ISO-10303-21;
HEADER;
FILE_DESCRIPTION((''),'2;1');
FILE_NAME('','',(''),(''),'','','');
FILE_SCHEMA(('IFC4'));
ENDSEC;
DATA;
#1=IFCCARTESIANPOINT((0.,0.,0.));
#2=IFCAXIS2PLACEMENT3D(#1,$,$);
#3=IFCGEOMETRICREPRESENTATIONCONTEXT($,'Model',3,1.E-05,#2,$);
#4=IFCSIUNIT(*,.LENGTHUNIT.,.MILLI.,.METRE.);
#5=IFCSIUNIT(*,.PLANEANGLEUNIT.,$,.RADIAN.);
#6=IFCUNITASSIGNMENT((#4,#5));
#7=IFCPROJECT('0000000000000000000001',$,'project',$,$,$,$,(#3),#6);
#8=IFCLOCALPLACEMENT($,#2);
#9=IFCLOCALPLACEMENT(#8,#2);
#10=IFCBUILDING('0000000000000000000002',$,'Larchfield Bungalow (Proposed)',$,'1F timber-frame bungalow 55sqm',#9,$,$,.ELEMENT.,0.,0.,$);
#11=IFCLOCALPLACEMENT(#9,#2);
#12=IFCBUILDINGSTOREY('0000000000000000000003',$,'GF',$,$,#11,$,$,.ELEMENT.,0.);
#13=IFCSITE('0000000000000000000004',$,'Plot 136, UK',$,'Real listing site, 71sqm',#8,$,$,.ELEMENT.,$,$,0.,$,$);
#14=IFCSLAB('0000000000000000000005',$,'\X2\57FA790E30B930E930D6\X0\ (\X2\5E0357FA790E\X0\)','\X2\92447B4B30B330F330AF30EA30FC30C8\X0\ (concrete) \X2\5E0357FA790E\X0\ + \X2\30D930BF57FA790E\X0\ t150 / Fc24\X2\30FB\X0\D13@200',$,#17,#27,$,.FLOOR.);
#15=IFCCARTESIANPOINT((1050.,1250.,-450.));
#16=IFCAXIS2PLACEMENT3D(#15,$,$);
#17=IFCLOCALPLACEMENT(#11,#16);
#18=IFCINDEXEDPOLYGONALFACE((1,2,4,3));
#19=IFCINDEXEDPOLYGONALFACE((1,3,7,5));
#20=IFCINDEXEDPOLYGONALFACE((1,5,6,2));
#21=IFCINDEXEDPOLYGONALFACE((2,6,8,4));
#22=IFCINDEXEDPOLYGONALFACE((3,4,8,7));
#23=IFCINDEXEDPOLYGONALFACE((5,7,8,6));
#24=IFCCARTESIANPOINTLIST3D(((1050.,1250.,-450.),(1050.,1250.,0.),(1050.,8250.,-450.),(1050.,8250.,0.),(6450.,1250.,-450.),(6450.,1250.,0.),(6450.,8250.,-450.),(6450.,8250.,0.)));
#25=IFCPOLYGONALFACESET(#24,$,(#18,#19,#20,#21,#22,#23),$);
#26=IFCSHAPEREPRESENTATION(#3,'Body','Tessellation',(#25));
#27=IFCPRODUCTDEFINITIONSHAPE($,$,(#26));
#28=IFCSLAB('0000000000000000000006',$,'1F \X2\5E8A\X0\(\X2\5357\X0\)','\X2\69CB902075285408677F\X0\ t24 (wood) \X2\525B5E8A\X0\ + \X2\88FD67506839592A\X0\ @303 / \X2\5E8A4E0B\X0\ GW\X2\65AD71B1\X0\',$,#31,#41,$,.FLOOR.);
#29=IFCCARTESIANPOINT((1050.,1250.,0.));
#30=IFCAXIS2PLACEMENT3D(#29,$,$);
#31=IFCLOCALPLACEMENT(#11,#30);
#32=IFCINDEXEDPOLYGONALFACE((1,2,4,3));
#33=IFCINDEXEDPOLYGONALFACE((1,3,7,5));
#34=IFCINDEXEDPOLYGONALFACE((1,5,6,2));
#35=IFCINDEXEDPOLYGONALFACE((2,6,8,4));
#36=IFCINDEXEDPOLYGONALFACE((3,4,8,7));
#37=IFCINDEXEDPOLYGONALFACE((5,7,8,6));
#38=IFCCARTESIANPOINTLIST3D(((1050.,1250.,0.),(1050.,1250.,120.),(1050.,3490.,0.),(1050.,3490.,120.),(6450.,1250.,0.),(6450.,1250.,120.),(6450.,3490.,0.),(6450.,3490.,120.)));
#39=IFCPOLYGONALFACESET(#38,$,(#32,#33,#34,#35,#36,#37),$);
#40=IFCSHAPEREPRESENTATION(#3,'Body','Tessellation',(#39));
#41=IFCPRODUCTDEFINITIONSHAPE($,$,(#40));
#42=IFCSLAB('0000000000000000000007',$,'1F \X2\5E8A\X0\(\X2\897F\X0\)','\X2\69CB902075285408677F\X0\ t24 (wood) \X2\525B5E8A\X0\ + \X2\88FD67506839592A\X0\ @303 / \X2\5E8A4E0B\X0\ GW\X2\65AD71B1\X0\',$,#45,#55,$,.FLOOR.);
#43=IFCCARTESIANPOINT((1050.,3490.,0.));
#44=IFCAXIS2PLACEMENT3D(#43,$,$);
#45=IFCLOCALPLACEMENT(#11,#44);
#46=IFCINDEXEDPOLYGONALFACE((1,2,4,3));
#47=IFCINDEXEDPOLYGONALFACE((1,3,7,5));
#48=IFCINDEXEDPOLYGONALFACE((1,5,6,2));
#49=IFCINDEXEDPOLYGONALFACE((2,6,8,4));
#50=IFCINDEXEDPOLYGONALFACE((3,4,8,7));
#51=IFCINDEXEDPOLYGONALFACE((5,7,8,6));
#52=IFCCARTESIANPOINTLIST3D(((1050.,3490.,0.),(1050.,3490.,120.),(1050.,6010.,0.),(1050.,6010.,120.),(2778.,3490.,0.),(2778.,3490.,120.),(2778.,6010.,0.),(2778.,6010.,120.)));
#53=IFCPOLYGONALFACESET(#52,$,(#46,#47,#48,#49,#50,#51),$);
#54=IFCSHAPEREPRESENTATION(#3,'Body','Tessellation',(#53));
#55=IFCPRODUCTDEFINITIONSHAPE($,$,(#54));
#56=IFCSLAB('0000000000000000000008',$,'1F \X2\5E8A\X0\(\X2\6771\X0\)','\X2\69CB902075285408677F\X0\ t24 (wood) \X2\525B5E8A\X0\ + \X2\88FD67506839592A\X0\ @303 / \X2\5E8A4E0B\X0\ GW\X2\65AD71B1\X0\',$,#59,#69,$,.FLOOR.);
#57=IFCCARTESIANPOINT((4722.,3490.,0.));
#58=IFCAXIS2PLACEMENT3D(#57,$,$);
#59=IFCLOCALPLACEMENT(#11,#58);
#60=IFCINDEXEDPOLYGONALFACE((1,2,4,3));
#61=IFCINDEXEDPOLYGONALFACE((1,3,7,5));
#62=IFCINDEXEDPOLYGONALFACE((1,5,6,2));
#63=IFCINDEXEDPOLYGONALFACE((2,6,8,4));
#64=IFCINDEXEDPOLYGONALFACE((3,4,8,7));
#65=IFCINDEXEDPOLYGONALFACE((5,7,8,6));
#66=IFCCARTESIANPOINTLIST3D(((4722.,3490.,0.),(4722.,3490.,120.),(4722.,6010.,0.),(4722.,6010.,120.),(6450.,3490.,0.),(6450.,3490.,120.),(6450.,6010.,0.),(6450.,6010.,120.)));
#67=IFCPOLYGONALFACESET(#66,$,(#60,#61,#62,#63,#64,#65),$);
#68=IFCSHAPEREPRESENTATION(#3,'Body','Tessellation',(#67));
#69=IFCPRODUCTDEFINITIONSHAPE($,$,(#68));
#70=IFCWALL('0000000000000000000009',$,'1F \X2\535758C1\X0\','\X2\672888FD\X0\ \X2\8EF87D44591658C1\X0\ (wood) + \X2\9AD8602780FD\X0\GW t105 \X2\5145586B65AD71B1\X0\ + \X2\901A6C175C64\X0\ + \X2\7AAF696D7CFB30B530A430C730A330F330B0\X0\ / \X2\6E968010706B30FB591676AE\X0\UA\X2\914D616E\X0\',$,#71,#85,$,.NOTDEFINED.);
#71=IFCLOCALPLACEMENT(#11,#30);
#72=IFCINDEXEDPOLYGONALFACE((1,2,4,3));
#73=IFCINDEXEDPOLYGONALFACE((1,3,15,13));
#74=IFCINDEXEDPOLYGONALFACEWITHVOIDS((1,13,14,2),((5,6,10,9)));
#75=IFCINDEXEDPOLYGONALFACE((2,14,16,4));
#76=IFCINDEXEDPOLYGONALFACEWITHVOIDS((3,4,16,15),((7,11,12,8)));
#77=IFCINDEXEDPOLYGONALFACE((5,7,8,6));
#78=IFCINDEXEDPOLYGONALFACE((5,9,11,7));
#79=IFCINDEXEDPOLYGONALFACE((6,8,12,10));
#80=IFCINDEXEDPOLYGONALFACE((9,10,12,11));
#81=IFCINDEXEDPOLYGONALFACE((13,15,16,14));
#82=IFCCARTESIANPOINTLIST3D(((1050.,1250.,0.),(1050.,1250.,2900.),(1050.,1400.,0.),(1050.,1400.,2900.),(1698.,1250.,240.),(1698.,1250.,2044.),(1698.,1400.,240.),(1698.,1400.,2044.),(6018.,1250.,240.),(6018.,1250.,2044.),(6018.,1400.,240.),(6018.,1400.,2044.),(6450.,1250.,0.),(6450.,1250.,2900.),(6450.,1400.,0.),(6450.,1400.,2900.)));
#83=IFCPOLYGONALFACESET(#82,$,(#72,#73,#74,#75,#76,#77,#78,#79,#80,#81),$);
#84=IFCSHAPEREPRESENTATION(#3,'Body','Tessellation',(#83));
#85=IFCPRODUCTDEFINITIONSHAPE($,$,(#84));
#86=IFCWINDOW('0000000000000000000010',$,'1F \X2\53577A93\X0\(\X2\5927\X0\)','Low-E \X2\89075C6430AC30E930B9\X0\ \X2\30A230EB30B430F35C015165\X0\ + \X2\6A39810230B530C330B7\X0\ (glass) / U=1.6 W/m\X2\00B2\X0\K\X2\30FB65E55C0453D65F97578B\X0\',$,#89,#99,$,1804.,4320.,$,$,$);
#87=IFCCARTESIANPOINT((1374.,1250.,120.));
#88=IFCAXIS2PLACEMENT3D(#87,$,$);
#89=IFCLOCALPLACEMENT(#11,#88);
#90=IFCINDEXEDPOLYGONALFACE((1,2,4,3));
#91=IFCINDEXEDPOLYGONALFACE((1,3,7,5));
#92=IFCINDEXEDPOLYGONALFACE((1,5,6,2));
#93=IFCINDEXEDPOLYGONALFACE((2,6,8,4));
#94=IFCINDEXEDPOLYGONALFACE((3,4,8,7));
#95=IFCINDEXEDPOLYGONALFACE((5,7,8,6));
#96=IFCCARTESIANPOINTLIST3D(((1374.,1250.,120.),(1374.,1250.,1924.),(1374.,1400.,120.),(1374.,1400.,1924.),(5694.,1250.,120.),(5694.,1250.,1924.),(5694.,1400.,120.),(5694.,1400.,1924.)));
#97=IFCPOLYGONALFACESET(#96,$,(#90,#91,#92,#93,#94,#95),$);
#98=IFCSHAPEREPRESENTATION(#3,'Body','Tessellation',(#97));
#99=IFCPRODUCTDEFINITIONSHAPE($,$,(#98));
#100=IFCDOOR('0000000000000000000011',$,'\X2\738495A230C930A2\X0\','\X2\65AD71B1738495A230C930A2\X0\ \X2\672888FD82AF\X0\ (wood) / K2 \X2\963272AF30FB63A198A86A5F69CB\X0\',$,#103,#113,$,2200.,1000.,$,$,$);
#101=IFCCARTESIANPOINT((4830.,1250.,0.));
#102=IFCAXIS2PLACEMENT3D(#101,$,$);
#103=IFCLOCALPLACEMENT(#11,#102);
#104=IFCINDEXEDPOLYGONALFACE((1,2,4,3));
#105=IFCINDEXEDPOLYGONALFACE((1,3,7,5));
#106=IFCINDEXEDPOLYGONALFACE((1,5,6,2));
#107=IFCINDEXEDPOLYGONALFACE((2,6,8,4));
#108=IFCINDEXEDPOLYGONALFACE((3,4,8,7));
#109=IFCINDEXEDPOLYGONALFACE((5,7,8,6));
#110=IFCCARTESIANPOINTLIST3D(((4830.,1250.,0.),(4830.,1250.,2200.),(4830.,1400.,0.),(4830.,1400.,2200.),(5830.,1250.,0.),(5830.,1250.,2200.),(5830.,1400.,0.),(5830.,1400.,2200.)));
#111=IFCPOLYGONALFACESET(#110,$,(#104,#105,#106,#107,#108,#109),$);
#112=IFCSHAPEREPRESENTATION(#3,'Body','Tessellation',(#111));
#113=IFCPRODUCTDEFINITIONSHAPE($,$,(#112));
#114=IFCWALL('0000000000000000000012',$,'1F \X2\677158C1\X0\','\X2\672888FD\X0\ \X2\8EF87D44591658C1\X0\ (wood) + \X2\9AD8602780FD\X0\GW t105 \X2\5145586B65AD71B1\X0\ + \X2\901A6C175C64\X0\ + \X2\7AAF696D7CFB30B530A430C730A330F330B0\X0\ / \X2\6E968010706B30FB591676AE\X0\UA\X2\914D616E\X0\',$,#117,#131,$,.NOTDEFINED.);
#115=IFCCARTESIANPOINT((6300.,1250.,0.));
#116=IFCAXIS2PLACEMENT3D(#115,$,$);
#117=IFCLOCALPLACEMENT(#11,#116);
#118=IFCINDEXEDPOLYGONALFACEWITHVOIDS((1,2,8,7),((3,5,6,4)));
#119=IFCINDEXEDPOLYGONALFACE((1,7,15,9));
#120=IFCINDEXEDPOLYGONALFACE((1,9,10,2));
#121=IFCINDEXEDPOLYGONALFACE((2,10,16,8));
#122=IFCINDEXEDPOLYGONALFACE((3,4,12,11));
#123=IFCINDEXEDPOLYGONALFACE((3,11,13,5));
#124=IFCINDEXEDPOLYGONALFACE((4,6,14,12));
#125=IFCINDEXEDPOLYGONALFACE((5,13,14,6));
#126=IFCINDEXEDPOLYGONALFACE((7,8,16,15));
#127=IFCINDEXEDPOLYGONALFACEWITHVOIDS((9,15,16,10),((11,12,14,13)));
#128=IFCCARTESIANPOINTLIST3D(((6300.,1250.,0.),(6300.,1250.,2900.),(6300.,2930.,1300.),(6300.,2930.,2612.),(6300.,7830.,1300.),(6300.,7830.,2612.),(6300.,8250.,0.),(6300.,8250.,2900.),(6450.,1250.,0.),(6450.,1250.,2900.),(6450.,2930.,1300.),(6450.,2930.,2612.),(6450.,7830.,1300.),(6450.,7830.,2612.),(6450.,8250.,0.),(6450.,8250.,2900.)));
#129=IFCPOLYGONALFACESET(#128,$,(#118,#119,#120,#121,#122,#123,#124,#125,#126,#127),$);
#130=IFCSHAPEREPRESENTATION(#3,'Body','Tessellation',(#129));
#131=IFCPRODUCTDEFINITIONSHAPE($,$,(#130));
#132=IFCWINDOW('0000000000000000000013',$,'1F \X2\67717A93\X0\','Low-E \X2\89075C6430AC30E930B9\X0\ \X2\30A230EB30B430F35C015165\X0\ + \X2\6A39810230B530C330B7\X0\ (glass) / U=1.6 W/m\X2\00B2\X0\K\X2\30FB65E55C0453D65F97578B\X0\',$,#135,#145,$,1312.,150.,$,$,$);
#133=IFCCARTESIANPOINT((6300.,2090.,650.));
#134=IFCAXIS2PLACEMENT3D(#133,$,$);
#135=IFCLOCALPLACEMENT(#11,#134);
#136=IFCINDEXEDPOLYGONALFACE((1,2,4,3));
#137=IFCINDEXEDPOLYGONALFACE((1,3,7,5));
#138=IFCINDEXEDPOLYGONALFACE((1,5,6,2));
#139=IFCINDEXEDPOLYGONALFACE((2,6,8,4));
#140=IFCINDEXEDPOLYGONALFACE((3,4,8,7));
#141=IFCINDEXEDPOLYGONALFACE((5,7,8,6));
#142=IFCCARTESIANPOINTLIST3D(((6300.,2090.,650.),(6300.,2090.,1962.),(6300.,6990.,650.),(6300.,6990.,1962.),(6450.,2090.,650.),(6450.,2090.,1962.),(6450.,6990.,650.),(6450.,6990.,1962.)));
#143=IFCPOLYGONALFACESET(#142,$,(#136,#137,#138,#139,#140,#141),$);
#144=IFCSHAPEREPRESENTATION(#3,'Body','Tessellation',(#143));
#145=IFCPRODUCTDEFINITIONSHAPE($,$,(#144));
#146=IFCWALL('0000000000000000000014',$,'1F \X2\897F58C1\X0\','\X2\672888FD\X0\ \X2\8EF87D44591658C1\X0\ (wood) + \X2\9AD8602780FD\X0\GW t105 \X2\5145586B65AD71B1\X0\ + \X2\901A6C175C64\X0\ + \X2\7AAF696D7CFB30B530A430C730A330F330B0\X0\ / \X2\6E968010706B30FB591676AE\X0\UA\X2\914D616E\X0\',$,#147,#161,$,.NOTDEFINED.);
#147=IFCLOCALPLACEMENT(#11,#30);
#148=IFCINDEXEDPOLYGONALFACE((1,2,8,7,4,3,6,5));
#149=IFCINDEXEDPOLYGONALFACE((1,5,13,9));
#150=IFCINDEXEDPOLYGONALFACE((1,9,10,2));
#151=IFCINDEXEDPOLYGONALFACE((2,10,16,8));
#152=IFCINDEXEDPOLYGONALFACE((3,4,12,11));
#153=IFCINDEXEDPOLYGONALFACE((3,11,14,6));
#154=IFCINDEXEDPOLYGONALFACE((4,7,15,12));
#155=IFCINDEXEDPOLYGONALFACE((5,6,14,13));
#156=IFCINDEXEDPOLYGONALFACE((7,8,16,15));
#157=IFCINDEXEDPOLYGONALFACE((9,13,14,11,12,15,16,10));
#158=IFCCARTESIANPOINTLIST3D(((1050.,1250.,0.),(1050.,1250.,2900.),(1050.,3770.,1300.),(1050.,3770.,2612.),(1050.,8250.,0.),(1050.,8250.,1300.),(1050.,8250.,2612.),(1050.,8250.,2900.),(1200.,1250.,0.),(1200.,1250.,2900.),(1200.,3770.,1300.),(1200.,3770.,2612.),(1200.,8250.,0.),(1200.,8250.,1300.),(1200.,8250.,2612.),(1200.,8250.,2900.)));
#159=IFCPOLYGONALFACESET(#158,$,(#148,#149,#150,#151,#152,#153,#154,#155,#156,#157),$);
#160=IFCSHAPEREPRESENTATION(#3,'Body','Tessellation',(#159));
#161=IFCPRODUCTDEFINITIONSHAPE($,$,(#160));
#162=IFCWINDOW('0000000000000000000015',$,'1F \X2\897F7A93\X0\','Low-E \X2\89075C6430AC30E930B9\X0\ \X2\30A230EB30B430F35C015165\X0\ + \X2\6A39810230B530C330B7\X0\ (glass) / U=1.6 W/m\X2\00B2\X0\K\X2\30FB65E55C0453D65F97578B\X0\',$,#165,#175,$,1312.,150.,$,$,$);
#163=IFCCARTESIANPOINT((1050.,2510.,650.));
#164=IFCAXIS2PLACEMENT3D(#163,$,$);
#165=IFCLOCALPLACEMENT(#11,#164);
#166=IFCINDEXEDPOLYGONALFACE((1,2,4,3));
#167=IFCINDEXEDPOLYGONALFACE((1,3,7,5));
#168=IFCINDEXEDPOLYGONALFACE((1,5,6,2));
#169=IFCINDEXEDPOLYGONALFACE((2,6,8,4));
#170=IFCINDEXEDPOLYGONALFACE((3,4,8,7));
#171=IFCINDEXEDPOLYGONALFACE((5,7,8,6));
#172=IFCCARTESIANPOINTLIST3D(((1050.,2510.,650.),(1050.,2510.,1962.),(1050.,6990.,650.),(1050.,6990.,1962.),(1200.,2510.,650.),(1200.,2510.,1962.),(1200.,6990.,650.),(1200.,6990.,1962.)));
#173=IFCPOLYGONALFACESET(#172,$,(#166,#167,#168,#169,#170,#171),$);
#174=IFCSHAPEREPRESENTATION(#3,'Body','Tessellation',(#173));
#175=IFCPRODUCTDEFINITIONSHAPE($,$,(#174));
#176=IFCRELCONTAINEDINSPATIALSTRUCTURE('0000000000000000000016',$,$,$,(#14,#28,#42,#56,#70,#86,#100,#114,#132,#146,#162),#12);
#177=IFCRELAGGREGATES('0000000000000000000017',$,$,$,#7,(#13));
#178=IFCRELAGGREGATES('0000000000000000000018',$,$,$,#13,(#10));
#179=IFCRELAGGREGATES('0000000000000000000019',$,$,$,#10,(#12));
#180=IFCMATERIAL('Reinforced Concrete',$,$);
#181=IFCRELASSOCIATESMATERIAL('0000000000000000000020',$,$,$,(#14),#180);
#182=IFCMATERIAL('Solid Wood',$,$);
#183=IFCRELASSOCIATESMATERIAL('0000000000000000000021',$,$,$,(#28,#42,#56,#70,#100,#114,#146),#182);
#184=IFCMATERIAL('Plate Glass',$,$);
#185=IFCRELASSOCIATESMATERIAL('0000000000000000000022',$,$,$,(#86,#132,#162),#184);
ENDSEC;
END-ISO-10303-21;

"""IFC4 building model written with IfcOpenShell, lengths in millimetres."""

from ifc_helpers import new_model, si_unit, frame, frame_2d, origin, place, context, project, spatial, rectangle, extrude, material, element, fill, save


model = new_model("IFC4")

# Units and contexts
model_context = context("Model", 3, precision=1e-05, world=origin())
ifc_project = project(units=[si_unit("LENGTHUNIT", "METRE", prefix="MILLI"), si_unit("PLANEANGLEUNIT", "RADIAN")], contexts=[model_context])

# Site, building, storey
site_placement = place(None, origin())
site = spatial("IfcSite", under=ifc_project, at=site_placement, Name="Plot 136, UK", ObjectType="Real listing site, 71sqm", CompositionType="ELEMENT", RefElevation=0.0)
building_placement = place(site_placement, origin())
building = spatial("IfcBuilding", under=site, at=building_placement, Name="Larchfield Bungalow (Proposed)", ObjectType="1F timber-frame bungalow 55sqm", CompositionType="ELEMENT", ElevationOfRefHeight=0.0, ElevationOfTerrain=0.0)
storey_placement = place(building_placement, origin())
storey = spatial("IfcBuildingStorey", under=building, at=storey_placement, Name="GF", CompositionType="ELEMENT", Elevation=0.0)

# Slabs
ifc_material_1 = material(Name="Reinforced Concrete")
slab_1_placement = place(storey_placement, frame((1050.0, 1250.0, -450.0)))
element("IfcSlab", 1, at=slab_1_placement, inside=storey, material=ifc_material_1, Name="基礎スラブ (布基礎)", Description="鉄筋コンクリート (concrete) 布基礎 + ベタ基礎 t150 / Fc24・D13@200", PredefinedType="FLOOR", context=model_context, shape_type="SweptSolid", body=[
    extrude(rectangle(XDim=5400.0, YDim=7000.0, at=frame_2d((2700.0, 3500.0))), frame((1050.0, 1250.0, -450.0)), (0.0, 0.0, 1.0), 450.0),
])
ifc_material_2 = material(Name="Solid Wood")
slab_2_placement = place(storey_placement, frame((1050.0, 1250.0, 0.0)))
element("IfcSlab", 2, at=slab_2_placement, inside=storey, material=ifc_material_2, Name="1F 床(南)", Description="構造用合板 t24 (wood) 剛床 + 製材根太 @303 / 床下 GW断熱", PredefinedType="FLOOR", context=model_context, shape_type="SweptSolid", body=[
    extrude(rectangle(XDim=5400.0, YDim=2240.0, at=frame_2d((2700.0, 1120.0))), frame((1050.0, 1250.0, 0.0)), (0.0, 0.0, 1.0), 120.0),
])
slab_3_placement = place(storey_placement, frame((1050.0, 3490.0, 0.0)))
element("IfcSlab", 3, at=slab_3_placement, inside=storey, material=ifc_material_2, Name="1F 床(西)", Description="構造用合板 t24 (wood) 剛床 + 製材根太 @303 / 床下 GW断熱", PredefinedType="FLOOR", context=model_context, shape_type="SweptSolid", body=[
    extrude(rectangle(XDim=1728.0, YDim=2520.0, at=frame_2d((864.0, 1260.0))), frame((1050.0, 3490.0, 0.0)), (0.0, 0.0, 1.0), 120.0),
])
slab_4_placement = place(storey_placement, frame((4722.0, 3490.0, 0.0)))
element("IfcSlab", 4, at=slab_4_placement, inside=storey, material=ifc_material_2, Name="1F 床(東)", Description="構造用合板 t24 (wood) 剛床 + 製材根太 @303 / 床下 GW断熱", PredefinedType="FLOOR", context=model_context, shape_type="SweptSolid", body=[
    extrude(rectangle(XDim=1728.0, YDim=2520.0, at=frame_2d((864.0, 1260.0))), frame((4722.0, 3490.0, 0.0)), (0.0, 0.0, 1.0), 120.0),
])

# Wall, openings, window, door
wall_1_placement = place(storey_placement, frame((1050.0, 1250.0, 0.0)))
wall_1 = element("IfcWall", 5, at=wall_1_placement, inside=storey, material=ifc_material_2, Name="1F 南壁", Description="木製 軸組外壁 (wood) + 高性能GW t105 充填断熱 + 通気層 + 窯業系サイディング / 準耐火・外皮UA配慮", PredefinedType="NOTDEFINED", context=model_context, shape_type="SweptSolid", body=[
    extrude(rectangle(XDim=5400.0, YDim=150.0, at=frame_2d((2700.0, 75.0))), frame((1050.0, 1250.0, 0.0)), (0.0, 0.0, 1.0), 2900.0),
])
opening_1_placement = place(storey_placement, frame((1374.0, 1250.0, 120.0)))
opening_1 = element("IfcOpeningElement", 6, at=opening_1_placement, cuts=wall_1, PredefinedType="NOTDEFINED", context=model_context, shape_type="SweptSolid", body=[
    extrude(rectangle(XDim=4320.0, YDim=150.0, at=frame_2d((2160.0, 75.0))), frame((1374.0, 1250.0, 120.0)), (0.0, 0.0, 1.0), 1804.0),
])
opening_2_placement = place(storey_placement, frame((4830.0, 1250.0, 0.0)))
opening_2 = element("IfcOpeningElement", 7, at=opening_2_placement, cuts=wall_1, PredefinedType="NOTDEFINED", context=model_context, shape_type="SweptSolid", body=[
    extrude(rectangle(XDim=1000.0, YDim=150.0, at=frame_2d((500.0, 75.0))), frame((4830.0, 1250.0, 0.0)), (0.0, 0.0, 1.0), 2200.0),
])
ifc_material_3 = material(Name="Plate Glass")
window_1_placement = place(storey_placement, frame((1374.0, 1250.0, 120.0)))
window_1 = element("IfcWindow", 8, at=window_1_placement, inside=storey, material=ifc_material_3, Name="1F 南窓(大)", Description="Low-E 複層ガラス アルゴン封入 + 樹脂サッシ (glass) / U=1.6 W/m²K・日射取得型", OverallHeight=1804.0, OverallWidth=4320.0, context=model_context, shape_type="SweptSolid", body=[
    extrude(rectangle(XDim=4320.0, YDim=150.0, at=frame_2d((2160.0, 75.0))), frame((1374.0, 1250.0, 120.0)), (0.0, 0.0, 1.0), 1804.0),
])
fill(opening_1, window_1)
door_placement = place(storey_placement, frame((4830.0, 1250.0, 0.0)))
door = element("IfcDoor", 9, at=door_placement, inside=storey, material=ifc_material_2, Name="玄関ドア", Description="断熱玄関ドア 木製芯 (wood) / K2 防犯・採風機構", OverallHeight=2200.0, OverallWidth=1000.0, context=model_context, shape_type="SweptSolid", body=[
    extrude(rectangle(XDim=1000.0, YDim=150.0, at=frame_2d((500.0, 75.0))), frame((4830.0, 1250.0, 0.0)), (0.0, 0.0, 1.0), 2200.0),
])
fill(opening_2, door)

# Walls, openings, windows
wall_2_placement = place(storey_placement, frame((6300.0, 1250.0, 0.0)))
wall_2 = element("IfcWall", 10, at=wall_2_placement, inside=storey, material=ifc_material_2, Name="1F 東壁", Description="木製 軸組外壁 (wood) + 高性能GW t105 充填断熱 + 通気層 + 窯業系サイディング / 準耐火・外皮UA配慮", PredefinedType="NOTDEFINED", context=model_context, shape_type="SweptSolid", body=[
    extrude(rectangle(XDim=150.0, YDim=7000.0, at=frame_2d((75.0, 3500.0))), frame((6300.0, 1250.0, 0.0)), (0.0, 0.0, 1.0), 2900.0),
])
opening_3_placement = place(storey_placement, frame((6300.0, 2090.0, 650.0)))
opening_3 = element("IfcOpeningElement", 11, at=opening_3_placement, cuts=wall_2, PredefinedType="NOTDEFINED", context=model_context, shape_type="SweptSolid", body=[
    extrude(rectangle(XDim=150.0, YDim=4900.0, at=frame_2d((75.0, 2450.0))), frame((6300.0, 2090.0, 650.0)), (0.0, 0.0, 1.0), 1312.0),
])
window_2_placement = place(storey_placement, frame((6300.0, 2090.0, 650.0)))
window_2 = element("IfcWindow", 12, at=window_2_placement, inside=storey, material=ifc_material_3, Name="1F 東窓", Description="Low-E 複層ガラス アルゴン封入 + 樹脂サッシ (glass) / U=1.6 W/m²K・日射取得型", OverallHeight=1312.0, OverallWidth=150.0, context=model_context, shape_type="SweptSolid", body=[
    extrude(rectangle(XDim=150.0, YDim=4900.0, at=frame_2d((75.0, 2450.0))), frame((6300.0, 2090.0, 650.0)), (0.0, 0.0, 1.0), 1312.0),
])
fill(opening_3, window_2)
wall_3_placement = place(storey_placement, frame((1050.0, 1250.0, 0.0)))
wall_3 = element("IfcWall", 13, at=wall_3_placement, inside=storey, material=ifc_material_2, Name="1F 西壁", Description="木製 軸組外壁 (wood) + 高性能GW t105 充填断熱 + 通気層 + 窯業系サイディング / 準耐火・外皮UA配慮", PredefinedType="NOTDEFINED", context=model_context, shape_type="SweptSolid", body=[
    extrude(rectangle(XDim=150.0, YDim=7000.0, at=frame_2d((75.0, 3500.0))), frame((1050.0, 1250.0, 0.0)), (0.0, 0.0, 1.0), 2900.0),
])
opening_4_placement = place(storey_placement, frame((1050.0, 2510.0, 650.0)))
opening_4 = element("IfcOpeningElement", 14, at=opening_4_placement, cuts=wall_3, PredefinedType="NOTDEFINED", context=model_context, shape_type="SweptSolid", body=[
    extrude(rectangle(XDim=150.0, YDim=4480.0, at=frame_2d((75.0, 2240.0))), frame((1050.0, 2510.0, 650.0)), (0.0, 0.0, 1.0), 1312.0),
])
window_3_placement = place(storey_placement, frame((1050.0, 2510.0, 650.0)))
window_3 = element("IfcWindow", 15, at=window_3_placement, inside=storey, material=ifc_material_3, Name="1F 西窓", Description="Low-E 複層ガラス アルゴン封入 + 樹脂サッシ (glass) / U=1.6 W/m²K・日射取得型", OverallHeight=1312.0, OverallWidth=150.0, context=model_context, shape_type="SweptSolid", body=[
    extrude(rectangle(XDim=150.0, YDim=4480.0, at=frame_2d((75.0, 2240.0))), frame((1050.0, 2510.0, 650.0)), (0.0, 0.0, 1.0), 1312.0),
])
fill(opening_4, window_3)

save(model, "model.ifc")
